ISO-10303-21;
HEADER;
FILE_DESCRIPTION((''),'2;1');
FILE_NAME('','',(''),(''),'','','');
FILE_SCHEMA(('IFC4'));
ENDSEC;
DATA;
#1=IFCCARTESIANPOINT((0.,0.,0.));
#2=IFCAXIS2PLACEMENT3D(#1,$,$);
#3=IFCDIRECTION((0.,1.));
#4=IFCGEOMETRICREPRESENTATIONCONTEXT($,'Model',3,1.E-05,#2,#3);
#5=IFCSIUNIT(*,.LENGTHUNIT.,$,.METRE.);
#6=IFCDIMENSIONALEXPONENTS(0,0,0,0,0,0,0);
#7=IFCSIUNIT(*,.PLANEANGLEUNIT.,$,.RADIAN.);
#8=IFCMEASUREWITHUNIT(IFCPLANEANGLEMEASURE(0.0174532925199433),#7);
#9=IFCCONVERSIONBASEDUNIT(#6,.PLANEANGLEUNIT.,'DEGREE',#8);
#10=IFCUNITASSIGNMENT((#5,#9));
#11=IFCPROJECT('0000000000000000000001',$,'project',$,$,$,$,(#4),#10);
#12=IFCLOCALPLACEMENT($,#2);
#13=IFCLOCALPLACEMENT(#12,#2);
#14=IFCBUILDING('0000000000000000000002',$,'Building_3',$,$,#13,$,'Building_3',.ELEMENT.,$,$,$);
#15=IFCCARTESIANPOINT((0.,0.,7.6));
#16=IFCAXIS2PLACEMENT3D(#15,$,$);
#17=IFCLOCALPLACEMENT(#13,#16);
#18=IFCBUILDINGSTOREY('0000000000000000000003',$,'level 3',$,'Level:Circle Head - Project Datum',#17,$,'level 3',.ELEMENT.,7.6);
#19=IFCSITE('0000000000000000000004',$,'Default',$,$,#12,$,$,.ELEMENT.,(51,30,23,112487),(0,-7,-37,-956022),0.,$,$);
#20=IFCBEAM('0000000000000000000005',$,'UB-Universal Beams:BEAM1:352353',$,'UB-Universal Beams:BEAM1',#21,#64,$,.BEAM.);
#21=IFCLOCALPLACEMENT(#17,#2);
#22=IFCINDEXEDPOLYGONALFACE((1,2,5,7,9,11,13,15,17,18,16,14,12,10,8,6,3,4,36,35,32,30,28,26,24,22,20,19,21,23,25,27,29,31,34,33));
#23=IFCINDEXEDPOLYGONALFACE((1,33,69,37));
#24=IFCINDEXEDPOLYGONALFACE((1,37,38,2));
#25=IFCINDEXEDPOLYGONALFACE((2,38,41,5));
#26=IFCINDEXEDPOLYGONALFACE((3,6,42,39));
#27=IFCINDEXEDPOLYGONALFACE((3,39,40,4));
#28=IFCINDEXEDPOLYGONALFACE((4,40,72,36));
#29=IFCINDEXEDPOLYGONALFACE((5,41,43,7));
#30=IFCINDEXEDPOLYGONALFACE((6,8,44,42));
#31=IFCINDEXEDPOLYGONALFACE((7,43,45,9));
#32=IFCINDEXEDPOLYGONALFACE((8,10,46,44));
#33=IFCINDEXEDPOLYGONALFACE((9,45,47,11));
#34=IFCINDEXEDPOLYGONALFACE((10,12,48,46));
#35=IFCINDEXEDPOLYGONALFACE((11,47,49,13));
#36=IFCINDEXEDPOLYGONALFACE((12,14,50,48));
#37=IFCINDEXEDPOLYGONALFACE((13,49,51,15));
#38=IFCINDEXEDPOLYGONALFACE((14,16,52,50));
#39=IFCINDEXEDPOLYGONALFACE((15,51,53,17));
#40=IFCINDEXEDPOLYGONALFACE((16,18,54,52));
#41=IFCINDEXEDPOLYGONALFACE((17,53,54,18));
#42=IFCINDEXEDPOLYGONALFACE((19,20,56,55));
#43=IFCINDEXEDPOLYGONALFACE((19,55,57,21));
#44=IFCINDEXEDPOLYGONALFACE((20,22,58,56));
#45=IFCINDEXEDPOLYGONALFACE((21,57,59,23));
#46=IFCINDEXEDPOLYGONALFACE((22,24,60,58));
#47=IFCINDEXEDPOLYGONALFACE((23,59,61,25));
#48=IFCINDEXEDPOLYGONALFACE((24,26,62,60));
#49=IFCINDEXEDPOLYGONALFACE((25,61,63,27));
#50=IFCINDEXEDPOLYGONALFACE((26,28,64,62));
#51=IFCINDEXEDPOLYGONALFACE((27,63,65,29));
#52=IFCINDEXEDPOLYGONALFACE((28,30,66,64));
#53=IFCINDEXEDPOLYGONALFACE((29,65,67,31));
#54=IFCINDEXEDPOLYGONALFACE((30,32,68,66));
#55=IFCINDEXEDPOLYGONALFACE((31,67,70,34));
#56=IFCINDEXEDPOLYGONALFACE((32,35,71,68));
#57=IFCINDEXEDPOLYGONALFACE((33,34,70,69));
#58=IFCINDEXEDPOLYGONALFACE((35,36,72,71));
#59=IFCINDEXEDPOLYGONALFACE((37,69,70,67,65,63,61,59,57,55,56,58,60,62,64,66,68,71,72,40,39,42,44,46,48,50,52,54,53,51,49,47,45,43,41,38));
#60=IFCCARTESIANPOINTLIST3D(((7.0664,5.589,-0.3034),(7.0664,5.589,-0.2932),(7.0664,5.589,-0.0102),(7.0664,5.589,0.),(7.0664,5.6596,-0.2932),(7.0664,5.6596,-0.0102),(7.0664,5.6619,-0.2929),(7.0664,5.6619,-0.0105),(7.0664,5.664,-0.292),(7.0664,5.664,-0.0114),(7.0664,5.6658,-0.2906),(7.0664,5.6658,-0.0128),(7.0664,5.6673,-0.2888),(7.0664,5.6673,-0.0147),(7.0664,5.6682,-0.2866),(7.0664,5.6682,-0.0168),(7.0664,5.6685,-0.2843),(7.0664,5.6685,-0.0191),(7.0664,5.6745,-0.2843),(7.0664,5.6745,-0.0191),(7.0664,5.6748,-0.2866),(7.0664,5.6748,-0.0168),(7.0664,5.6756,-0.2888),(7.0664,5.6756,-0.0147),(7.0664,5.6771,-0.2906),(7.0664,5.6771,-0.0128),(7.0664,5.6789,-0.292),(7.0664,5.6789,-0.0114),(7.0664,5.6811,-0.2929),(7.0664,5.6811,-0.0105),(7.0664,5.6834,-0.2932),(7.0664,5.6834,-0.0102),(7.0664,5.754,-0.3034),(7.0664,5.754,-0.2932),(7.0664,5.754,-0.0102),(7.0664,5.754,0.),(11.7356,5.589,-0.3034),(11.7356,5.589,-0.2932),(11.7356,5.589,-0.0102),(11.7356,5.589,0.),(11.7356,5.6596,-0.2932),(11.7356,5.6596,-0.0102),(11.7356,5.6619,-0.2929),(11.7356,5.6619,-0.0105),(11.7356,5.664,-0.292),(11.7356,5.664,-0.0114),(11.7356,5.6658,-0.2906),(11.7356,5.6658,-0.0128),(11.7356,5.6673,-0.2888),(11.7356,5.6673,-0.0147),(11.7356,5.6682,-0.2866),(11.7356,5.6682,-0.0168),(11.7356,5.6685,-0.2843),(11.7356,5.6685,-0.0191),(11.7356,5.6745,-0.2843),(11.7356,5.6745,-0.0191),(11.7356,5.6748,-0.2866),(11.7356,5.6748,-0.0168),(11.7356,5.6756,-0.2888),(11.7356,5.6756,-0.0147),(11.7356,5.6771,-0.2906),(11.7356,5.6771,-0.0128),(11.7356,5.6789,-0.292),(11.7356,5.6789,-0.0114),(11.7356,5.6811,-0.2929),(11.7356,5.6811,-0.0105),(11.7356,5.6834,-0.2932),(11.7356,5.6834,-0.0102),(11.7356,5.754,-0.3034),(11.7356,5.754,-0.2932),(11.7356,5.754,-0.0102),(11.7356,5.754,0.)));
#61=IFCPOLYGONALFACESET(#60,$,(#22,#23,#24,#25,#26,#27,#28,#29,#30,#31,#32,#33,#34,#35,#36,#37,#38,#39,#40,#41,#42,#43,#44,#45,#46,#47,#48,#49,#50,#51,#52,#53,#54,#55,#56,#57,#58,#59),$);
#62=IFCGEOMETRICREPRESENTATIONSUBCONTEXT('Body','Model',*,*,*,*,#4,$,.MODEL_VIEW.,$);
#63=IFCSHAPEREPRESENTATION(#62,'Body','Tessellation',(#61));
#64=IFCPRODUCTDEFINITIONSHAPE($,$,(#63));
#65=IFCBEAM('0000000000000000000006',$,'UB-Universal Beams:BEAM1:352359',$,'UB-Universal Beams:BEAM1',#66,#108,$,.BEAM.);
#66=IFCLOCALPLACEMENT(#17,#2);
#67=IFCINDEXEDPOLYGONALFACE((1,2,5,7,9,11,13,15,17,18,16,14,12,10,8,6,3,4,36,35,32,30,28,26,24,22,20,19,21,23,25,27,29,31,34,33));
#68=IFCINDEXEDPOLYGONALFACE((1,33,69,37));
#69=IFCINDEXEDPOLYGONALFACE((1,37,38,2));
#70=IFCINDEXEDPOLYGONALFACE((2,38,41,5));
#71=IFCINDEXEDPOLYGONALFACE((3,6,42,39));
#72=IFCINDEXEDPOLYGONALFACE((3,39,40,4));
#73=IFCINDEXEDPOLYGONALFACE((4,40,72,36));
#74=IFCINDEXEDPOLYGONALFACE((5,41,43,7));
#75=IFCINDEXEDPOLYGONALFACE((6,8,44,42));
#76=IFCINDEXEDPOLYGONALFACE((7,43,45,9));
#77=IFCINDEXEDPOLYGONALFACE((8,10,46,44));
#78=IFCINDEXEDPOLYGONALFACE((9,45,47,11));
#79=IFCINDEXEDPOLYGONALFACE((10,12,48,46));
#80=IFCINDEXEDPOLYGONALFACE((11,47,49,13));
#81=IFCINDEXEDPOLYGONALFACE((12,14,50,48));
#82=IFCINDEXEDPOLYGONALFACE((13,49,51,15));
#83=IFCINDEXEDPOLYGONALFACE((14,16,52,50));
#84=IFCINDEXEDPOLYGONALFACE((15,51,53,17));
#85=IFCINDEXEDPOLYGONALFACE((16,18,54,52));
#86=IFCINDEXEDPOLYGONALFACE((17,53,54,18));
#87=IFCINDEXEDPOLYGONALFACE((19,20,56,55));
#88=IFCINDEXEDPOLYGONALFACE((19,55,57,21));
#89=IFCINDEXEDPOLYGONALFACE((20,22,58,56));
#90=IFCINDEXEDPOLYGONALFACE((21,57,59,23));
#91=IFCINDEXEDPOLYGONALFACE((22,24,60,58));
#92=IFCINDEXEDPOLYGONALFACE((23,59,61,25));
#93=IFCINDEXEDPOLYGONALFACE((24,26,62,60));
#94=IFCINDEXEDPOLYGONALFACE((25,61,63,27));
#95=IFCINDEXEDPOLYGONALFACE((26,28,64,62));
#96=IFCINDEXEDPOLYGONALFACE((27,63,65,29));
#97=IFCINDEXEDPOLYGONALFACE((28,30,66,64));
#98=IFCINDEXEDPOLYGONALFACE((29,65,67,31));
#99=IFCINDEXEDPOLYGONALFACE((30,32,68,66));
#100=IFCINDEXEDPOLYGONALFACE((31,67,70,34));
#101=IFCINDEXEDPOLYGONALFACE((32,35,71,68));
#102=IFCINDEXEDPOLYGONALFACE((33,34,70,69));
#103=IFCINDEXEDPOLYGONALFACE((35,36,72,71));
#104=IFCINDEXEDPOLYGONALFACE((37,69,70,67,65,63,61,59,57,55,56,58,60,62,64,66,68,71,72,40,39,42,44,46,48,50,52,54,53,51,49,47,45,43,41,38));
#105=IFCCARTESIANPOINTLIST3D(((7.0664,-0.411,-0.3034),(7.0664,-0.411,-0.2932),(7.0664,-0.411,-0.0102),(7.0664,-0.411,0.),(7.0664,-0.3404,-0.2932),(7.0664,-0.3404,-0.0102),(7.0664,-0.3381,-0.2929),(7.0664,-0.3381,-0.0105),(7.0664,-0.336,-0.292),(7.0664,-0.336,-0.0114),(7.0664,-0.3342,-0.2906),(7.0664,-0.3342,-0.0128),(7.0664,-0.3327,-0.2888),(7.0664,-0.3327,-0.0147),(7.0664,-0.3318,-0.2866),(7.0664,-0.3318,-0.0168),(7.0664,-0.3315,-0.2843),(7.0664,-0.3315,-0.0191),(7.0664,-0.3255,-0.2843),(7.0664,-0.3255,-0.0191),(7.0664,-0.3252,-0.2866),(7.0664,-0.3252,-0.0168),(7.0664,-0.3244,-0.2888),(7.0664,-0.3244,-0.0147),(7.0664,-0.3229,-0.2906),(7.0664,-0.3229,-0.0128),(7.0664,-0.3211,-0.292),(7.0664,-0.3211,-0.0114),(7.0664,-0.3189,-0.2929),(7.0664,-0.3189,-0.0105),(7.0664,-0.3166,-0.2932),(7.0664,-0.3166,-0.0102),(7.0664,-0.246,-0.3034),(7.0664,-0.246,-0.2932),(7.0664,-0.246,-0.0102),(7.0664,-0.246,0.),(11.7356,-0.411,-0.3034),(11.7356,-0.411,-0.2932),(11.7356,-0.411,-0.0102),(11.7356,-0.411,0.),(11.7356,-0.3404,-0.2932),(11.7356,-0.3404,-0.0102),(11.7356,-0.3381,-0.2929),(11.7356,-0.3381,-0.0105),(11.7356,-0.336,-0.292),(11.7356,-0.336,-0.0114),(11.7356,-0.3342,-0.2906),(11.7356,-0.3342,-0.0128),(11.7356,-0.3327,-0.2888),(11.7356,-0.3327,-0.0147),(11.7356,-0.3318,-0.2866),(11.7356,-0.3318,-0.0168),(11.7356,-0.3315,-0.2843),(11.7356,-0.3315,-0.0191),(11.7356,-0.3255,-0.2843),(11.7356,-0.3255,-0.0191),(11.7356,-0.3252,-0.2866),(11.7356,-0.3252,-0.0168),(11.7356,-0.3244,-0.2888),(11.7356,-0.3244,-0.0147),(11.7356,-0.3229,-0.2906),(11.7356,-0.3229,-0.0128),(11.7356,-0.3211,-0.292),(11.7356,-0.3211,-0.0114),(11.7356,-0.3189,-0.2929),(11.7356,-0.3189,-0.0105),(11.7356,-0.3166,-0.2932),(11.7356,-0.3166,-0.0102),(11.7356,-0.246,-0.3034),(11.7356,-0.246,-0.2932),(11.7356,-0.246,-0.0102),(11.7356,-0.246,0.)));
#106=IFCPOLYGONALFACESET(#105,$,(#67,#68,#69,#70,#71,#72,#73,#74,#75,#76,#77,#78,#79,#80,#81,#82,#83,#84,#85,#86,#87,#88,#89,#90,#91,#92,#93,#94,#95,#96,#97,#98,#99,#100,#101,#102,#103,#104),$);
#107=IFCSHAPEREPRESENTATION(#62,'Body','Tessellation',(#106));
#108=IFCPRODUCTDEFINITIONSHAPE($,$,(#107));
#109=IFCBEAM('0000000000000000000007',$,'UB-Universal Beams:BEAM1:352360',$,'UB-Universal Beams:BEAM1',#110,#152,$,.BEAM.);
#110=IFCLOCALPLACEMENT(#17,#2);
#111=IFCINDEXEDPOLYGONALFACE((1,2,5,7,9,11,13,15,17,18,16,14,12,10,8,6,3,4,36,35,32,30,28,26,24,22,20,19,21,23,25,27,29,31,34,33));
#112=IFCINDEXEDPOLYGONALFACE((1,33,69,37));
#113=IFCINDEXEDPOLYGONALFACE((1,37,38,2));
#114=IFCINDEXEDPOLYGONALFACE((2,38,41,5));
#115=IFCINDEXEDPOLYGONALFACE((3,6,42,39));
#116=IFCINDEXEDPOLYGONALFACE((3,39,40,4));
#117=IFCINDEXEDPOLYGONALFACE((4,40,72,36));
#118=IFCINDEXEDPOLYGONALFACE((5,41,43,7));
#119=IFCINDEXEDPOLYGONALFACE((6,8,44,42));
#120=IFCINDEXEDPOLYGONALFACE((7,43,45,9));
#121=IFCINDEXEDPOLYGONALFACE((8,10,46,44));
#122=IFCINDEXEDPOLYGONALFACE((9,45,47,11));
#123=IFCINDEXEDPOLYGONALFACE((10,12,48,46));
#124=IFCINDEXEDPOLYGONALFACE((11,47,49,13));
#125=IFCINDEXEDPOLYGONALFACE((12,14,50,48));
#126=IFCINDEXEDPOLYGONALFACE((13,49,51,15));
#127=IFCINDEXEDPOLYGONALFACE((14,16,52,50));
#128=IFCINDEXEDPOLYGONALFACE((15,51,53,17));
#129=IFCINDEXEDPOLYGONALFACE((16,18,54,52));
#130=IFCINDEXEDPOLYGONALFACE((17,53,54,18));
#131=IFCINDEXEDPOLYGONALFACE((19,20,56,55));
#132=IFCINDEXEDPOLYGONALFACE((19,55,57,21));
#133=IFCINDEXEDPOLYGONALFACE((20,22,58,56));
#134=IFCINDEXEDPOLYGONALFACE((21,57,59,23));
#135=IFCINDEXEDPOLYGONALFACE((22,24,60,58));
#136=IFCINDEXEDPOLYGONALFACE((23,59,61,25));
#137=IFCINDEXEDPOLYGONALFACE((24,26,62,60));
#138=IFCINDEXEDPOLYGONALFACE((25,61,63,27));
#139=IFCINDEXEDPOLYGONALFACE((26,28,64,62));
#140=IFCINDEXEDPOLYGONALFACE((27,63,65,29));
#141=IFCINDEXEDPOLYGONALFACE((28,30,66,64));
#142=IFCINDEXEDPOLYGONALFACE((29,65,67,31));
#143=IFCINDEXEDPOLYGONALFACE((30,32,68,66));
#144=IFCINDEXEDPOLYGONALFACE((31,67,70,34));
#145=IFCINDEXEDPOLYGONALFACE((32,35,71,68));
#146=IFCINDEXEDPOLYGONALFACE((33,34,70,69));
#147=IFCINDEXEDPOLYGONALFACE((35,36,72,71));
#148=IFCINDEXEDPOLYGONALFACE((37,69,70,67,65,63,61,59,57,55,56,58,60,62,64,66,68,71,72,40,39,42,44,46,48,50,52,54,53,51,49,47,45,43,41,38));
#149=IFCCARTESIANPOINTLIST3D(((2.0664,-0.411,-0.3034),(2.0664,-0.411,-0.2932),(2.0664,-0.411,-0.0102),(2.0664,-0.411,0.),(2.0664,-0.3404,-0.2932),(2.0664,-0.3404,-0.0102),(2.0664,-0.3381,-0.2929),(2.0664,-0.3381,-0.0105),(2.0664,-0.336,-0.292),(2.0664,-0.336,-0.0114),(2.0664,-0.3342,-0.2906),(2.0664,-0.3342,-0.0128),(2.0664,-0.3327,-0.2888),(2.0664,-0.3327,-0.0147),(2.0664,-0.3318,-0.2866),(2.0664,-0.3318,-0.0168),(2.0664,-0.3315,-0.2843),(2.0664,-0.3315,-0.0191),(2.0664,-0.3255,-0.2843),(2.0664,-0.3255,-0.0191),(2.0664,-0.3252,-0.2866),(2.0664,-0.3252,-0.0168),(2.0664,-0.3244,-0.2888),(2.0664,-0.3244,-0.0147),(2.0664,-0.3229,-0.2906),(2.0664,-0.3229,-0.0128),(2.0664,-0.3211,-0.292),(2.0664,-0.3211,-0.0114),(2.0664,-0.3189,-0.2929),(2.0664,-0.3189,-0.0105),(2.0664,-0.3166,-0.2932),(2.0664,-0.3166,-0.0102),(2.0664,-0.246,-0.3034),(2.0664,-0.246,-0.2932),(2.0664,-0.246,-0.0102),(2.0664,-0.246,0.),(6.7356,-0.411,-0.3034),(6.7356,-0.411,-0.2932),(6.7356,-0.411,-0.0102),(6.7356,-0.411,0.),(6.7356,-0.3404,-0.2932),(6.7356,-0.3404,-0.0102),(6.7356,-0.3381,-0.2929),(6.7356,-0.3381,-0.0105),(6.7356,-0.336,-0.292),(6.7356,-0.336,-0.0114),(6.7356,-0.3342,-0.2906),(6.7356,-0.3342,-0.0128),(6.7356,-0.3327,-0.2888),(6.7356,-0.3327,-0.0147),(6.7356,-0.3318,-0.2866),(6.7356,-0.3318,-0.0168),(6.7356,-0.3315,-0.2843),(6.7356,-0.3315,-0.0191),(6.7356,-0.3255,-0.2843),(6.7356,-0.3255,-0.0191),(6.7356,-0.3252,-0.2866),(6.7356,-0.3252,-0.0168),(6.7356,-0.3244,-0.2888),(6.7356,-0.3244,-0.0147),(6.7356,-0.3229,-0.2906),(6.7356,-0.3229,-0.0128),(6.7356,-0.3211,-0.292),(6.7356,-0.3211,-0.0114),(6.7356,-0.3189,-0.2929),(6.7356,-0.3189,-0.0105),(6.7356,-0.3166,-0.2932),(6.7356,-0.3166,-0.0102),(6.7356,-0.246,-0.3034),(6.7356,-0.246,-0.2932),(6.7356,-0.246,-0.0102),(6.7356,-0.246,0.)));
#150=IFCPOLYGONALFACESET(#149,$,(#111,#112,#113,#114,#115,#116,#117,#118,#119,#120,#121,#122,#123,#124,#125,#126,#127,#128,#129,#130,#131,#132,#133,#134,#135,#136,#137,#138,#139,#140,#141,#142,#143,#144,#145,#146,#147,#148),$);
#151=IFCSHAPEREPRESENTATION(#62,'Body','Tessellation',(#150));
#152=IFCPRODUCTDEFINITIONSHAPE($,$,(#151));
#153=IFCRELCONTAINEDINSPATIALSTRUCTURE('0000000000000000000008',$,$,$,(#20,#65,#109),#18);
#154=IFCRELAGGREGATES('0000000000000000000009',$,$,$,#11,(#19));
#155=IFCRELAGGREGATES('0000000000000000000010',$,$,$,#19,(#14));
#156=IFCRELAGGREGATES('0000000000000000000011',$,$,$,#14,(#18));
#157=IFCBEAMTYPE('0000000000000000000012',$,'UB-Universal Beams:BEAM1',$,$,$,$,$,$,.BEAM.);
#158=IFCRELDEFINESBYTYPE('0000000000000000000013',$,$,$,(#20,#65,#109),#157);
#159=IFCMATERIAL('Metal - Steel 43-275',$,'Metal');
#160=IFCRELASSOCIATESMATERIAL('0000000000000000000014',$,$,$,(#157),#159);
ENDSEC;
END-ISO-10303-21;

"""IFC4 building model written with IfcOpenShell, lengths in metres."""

from ifc_helpers import new_model, entity, si_unit, converted_unit, direction, frame, frame_2d, origin, place, context, subcontext, project, spatial, polyline, circle_curve, parameter, trimmed, segment, composite_curve, outline, extrude, source, transform, mapped, material, material_profile, profile_set, type_object, type_shapes, element, save


model = new_model("IFC4")

# Units and contexts
model_context = context("Model", 3, precision=1e-05, world=origin(), true_north=direction((0.0, 1.0)))
body_context = subcontext(model_context, "Body", "Model", "MODEL_VIEW")
ifc_project = project(units=[si_unit("LENGTHUNIT", "METRE"), converted_unit("PLANEANGLEUNIT", "DEGREE", entity("IfcPlaneAngleMeasure", 0.0174532925199433), si_unit("PLANEANGLEUNIT", "RADIAN"), dimensions=[0, 0, 0, 0, 0, 0, 0])], contexts=[model_context])

# Site, building, storey
site_placement = place(None, origin())
site = spatial("IfcSite", under=ifc_project, at=site_placement, Name="Default", CompositionType="ELEMENT", RefLatitude=(51, 30, 23, 112487), RefLongitude=(0, -7, -37, -956022), RefElevation=0.0)
building_placement = place(site_placement, origin())
building = spatial("IfcBuilding", under=site, at=building_placement, Name="Building_3", LongName="Building_3", CompositionType="ELEMENT")
storey_placement = place(building_placement, frame((0.0, 0.0, 7.6)))
storey = spatial("IfcBuildingStorey", under=building, at=storey_placement, Name="level 3", ObjectType="Level:Circle Head - Project Datum", LongName="level 3", CompositionType="ELEMENT", Elevation=7.6)

# Shared definitions
ifc_material_1 = material(Name="Metal - Steel 43-275", Category="Metal")

# Beams
ifc_material_profile_1 = material_profile(ifc_material_1, outline(composite_curve([segment(polyline([(-0.0825, -0.1415), (-0.0825, -0.1517)]), True, "CONTINUOUS"), segment(polyline([(-0.0825, -0.1517), (0.0825, -0.1517)]), True, "CONTINUOUS"), segment(polyline([(0.0825, -0.1517), (0.0825, -0.1415)]), True, "CONTINUOUS"), segment(polyline([(0.0825, -0.1415), (0.0119, -0.1415)]), True, "CONTINUOUS"), segment(trimmed(circle_curve(frame_2d((0.0119, -0.1326), x_axis=(1.0, 0.0)), 0.0089), [parameter(180.0)], [parameter(270.0)], True, "PARAMETER"), False, "CONTINUOUS"), segment(polyline([(0.003, -0.1326), (0.003, 0.1326)]), True, "CONTINUOUS"), segment(trimmed(circle_curve(frame_2d((0.0119, 0.1326), x_axis=(1.0, 0.0)), 0.0089), [parameter(90.0)], [parameter(180.0)], True, "PARAMETER"), False, "CONTINUOUS"), segment(polyline([(0.0119, 0.1415), (0.0825, 0.1415)]), True, "CONTINUOUS"), segment(polyline([(0.0825, 0.1415), (0.0825, 0.1517)]), True, "CONTINUOUS"), segment(polyline([(0.0825, 0.1517), (-0.0825, 0.1517)]), True, "CONTINUOUS"), segment(polyline([(-0.0825, 0.1517), (-0.0825, 0.1415)]), True, "CONTINUOUS"), segment(polyline([(-0.0825, 0.1415), (-0.0119, 0.1415)]), True, "CONTINUOUS"), segment(trimmed(circle_curve(frame_2d((-0.0119, 0.1326), x_axis=(1.0, 0.0)), 0.0089), [parameter(360.0)], [parameter(90.0)], True, "PARAMETER"), False, "CONTINUOUS"), segment(polyline([(-0.003, 0.1326), (-0.003, -0.1326)]), True, "CONTINUOUS"), segment(trimmed(circle_curve(frame_2d((-0.0119, -0.1326), x_axis=(1.0, 0.0)), 0.0089), [parameter(270.0)], [parameter(360.0)], True, "PARAMETER"), False, "CONTINUOUS"), segment(polyline([(-0.0119, -0.1415), (-0.0825, -0.1415)]), True, "CONTINUOUS")], self_intersect=False)), Name="BEAM1")
ifc_profile_set_1 = profile_set([ifc_material_profile_1], Name="BEAM1")
beam_type_1 = type_object("IfcBeamType", Name="UB-Universal Beams:BEAM1", PredefinedType="BEAM", material=ifc_profile_set_1)
shared_shape_1 = source(origin(), body_context, "Body", "SweptSolid", [
    extrude(outline(composite_curve([segment(polyline([(-0.0825, -0.1415), (-0.0825, -0.1517)]), True, "CONTINUOUS"), segment(polyline([(-0.0825, -0.1517), (0.0825, -0.1517)]), True, "CONTINUOUS"), segment(polyline([(0.0825, -0.1517), (0.0825, -0.1415)]), True, "CONTINUOUS"), segment(polyline([(0.0825, -0.1415), (0.0119, -0.1415)]), True, "CONTINUOUS"), segment(trimmed(circle_curve(frame_2d((0.0119, -0.1326), x_axis=(1.0, 0.0)), 0.0089), [parameter(180.0)], [parameter(270.0)], True, "PARAMETER"), False, "CONTINUOUS"), segment(polyline([(0.003, -0.1326), (0.003, 0.1326)]), True, "CONTINUOUS"), segment(trimmed(circle_curve(frame_2d((0.0119, 0.1326), x_axis=(1.0, 0.0)), 0.0089), [parameter(90.0)], [parameter(180.0)], True, "PARAMETER"), False, "CONTINUOUS"), segment(polyline([(0.0119, 0.1415), (0.0825, 0.1415)]), True, "CONTINUOUS"), segment(polyline([(0.0825, 0.1415), (0.0825, 0.1517)]), True, "CONTINUOUS"), segment(polyline([(0.0825, 0.1517), (-0.0825, 0.1517)]), True, "CONTINUOUS"), segment(polyline([(-0.0825, 0.1517), (-0.0825, 0.1415)]), True, "CONTINUOUS"), segment(polyline([(-0.0825, 0.1415), (-0.0119, 0.1415)]), True, "CONTINUOUS"), segment(trimmed(circle_curve(frame_2d((-0.0119, 0.1326), x_axis=(1.0, 0.0)), 0.0089), [parameter(360.0)], [parameter(90.0)], True, "PARAMETER"), False, "CONTINUOUS"), segment(polyline([(-0.003, 0.1326), (-0.003, -0.1326)]), True, "CONTINUOUS"), segment(trimmed(circle_curve(frame_2d((-0.0119, -0.1326), x_axis=(1.0, 0.0)), 0.0089), [parameter(270.0)], [parameter(360.0)], True, "PARAMETER"), False, "CONTINUOUS"), segment(polyline([(-0.0119, -0.1415), (-0.0825, -0.1415)]), True, "CONTINUOUS")], self_intersect=False)), frame((-2.3346, 0.0, 0.0), z_axis=(-1.0, 0.0, 0.0), x_axis=(0.0, -1.0, 0.0)), (0.0, 0.0, -1.0), 4.6692),
])
type_shapes(beam_type_1, [shared_shape_1])
for number, where, name in (
    (1, (9.401, 5.6715, -0.1517), "UB-Universal Beams:BEAM1:352353"),
    (2, (9.401, -0.3285, -0.1517), "UB-Universal Beams:BEAM1:352359"),
    (3, (4.401, -0.3285, -0.1517), "UB-Universal Beams:BEAM1:352360"),
):
    element("IfcBeam", number, at=place(storey_placement, frame(where)), inside=storey, type_object=beam_type_1, Name=name, ObjectType="UB-Universal Beams:BEAM1", PredefinedType="BEAM", context=body_context, shape_type="MappedRepresentation", body=[
        mapped(shared_shape_1, transform((0.0, 0.0, 0.0), scale=1.0)),
    ])

save(model, "model.ifc")
